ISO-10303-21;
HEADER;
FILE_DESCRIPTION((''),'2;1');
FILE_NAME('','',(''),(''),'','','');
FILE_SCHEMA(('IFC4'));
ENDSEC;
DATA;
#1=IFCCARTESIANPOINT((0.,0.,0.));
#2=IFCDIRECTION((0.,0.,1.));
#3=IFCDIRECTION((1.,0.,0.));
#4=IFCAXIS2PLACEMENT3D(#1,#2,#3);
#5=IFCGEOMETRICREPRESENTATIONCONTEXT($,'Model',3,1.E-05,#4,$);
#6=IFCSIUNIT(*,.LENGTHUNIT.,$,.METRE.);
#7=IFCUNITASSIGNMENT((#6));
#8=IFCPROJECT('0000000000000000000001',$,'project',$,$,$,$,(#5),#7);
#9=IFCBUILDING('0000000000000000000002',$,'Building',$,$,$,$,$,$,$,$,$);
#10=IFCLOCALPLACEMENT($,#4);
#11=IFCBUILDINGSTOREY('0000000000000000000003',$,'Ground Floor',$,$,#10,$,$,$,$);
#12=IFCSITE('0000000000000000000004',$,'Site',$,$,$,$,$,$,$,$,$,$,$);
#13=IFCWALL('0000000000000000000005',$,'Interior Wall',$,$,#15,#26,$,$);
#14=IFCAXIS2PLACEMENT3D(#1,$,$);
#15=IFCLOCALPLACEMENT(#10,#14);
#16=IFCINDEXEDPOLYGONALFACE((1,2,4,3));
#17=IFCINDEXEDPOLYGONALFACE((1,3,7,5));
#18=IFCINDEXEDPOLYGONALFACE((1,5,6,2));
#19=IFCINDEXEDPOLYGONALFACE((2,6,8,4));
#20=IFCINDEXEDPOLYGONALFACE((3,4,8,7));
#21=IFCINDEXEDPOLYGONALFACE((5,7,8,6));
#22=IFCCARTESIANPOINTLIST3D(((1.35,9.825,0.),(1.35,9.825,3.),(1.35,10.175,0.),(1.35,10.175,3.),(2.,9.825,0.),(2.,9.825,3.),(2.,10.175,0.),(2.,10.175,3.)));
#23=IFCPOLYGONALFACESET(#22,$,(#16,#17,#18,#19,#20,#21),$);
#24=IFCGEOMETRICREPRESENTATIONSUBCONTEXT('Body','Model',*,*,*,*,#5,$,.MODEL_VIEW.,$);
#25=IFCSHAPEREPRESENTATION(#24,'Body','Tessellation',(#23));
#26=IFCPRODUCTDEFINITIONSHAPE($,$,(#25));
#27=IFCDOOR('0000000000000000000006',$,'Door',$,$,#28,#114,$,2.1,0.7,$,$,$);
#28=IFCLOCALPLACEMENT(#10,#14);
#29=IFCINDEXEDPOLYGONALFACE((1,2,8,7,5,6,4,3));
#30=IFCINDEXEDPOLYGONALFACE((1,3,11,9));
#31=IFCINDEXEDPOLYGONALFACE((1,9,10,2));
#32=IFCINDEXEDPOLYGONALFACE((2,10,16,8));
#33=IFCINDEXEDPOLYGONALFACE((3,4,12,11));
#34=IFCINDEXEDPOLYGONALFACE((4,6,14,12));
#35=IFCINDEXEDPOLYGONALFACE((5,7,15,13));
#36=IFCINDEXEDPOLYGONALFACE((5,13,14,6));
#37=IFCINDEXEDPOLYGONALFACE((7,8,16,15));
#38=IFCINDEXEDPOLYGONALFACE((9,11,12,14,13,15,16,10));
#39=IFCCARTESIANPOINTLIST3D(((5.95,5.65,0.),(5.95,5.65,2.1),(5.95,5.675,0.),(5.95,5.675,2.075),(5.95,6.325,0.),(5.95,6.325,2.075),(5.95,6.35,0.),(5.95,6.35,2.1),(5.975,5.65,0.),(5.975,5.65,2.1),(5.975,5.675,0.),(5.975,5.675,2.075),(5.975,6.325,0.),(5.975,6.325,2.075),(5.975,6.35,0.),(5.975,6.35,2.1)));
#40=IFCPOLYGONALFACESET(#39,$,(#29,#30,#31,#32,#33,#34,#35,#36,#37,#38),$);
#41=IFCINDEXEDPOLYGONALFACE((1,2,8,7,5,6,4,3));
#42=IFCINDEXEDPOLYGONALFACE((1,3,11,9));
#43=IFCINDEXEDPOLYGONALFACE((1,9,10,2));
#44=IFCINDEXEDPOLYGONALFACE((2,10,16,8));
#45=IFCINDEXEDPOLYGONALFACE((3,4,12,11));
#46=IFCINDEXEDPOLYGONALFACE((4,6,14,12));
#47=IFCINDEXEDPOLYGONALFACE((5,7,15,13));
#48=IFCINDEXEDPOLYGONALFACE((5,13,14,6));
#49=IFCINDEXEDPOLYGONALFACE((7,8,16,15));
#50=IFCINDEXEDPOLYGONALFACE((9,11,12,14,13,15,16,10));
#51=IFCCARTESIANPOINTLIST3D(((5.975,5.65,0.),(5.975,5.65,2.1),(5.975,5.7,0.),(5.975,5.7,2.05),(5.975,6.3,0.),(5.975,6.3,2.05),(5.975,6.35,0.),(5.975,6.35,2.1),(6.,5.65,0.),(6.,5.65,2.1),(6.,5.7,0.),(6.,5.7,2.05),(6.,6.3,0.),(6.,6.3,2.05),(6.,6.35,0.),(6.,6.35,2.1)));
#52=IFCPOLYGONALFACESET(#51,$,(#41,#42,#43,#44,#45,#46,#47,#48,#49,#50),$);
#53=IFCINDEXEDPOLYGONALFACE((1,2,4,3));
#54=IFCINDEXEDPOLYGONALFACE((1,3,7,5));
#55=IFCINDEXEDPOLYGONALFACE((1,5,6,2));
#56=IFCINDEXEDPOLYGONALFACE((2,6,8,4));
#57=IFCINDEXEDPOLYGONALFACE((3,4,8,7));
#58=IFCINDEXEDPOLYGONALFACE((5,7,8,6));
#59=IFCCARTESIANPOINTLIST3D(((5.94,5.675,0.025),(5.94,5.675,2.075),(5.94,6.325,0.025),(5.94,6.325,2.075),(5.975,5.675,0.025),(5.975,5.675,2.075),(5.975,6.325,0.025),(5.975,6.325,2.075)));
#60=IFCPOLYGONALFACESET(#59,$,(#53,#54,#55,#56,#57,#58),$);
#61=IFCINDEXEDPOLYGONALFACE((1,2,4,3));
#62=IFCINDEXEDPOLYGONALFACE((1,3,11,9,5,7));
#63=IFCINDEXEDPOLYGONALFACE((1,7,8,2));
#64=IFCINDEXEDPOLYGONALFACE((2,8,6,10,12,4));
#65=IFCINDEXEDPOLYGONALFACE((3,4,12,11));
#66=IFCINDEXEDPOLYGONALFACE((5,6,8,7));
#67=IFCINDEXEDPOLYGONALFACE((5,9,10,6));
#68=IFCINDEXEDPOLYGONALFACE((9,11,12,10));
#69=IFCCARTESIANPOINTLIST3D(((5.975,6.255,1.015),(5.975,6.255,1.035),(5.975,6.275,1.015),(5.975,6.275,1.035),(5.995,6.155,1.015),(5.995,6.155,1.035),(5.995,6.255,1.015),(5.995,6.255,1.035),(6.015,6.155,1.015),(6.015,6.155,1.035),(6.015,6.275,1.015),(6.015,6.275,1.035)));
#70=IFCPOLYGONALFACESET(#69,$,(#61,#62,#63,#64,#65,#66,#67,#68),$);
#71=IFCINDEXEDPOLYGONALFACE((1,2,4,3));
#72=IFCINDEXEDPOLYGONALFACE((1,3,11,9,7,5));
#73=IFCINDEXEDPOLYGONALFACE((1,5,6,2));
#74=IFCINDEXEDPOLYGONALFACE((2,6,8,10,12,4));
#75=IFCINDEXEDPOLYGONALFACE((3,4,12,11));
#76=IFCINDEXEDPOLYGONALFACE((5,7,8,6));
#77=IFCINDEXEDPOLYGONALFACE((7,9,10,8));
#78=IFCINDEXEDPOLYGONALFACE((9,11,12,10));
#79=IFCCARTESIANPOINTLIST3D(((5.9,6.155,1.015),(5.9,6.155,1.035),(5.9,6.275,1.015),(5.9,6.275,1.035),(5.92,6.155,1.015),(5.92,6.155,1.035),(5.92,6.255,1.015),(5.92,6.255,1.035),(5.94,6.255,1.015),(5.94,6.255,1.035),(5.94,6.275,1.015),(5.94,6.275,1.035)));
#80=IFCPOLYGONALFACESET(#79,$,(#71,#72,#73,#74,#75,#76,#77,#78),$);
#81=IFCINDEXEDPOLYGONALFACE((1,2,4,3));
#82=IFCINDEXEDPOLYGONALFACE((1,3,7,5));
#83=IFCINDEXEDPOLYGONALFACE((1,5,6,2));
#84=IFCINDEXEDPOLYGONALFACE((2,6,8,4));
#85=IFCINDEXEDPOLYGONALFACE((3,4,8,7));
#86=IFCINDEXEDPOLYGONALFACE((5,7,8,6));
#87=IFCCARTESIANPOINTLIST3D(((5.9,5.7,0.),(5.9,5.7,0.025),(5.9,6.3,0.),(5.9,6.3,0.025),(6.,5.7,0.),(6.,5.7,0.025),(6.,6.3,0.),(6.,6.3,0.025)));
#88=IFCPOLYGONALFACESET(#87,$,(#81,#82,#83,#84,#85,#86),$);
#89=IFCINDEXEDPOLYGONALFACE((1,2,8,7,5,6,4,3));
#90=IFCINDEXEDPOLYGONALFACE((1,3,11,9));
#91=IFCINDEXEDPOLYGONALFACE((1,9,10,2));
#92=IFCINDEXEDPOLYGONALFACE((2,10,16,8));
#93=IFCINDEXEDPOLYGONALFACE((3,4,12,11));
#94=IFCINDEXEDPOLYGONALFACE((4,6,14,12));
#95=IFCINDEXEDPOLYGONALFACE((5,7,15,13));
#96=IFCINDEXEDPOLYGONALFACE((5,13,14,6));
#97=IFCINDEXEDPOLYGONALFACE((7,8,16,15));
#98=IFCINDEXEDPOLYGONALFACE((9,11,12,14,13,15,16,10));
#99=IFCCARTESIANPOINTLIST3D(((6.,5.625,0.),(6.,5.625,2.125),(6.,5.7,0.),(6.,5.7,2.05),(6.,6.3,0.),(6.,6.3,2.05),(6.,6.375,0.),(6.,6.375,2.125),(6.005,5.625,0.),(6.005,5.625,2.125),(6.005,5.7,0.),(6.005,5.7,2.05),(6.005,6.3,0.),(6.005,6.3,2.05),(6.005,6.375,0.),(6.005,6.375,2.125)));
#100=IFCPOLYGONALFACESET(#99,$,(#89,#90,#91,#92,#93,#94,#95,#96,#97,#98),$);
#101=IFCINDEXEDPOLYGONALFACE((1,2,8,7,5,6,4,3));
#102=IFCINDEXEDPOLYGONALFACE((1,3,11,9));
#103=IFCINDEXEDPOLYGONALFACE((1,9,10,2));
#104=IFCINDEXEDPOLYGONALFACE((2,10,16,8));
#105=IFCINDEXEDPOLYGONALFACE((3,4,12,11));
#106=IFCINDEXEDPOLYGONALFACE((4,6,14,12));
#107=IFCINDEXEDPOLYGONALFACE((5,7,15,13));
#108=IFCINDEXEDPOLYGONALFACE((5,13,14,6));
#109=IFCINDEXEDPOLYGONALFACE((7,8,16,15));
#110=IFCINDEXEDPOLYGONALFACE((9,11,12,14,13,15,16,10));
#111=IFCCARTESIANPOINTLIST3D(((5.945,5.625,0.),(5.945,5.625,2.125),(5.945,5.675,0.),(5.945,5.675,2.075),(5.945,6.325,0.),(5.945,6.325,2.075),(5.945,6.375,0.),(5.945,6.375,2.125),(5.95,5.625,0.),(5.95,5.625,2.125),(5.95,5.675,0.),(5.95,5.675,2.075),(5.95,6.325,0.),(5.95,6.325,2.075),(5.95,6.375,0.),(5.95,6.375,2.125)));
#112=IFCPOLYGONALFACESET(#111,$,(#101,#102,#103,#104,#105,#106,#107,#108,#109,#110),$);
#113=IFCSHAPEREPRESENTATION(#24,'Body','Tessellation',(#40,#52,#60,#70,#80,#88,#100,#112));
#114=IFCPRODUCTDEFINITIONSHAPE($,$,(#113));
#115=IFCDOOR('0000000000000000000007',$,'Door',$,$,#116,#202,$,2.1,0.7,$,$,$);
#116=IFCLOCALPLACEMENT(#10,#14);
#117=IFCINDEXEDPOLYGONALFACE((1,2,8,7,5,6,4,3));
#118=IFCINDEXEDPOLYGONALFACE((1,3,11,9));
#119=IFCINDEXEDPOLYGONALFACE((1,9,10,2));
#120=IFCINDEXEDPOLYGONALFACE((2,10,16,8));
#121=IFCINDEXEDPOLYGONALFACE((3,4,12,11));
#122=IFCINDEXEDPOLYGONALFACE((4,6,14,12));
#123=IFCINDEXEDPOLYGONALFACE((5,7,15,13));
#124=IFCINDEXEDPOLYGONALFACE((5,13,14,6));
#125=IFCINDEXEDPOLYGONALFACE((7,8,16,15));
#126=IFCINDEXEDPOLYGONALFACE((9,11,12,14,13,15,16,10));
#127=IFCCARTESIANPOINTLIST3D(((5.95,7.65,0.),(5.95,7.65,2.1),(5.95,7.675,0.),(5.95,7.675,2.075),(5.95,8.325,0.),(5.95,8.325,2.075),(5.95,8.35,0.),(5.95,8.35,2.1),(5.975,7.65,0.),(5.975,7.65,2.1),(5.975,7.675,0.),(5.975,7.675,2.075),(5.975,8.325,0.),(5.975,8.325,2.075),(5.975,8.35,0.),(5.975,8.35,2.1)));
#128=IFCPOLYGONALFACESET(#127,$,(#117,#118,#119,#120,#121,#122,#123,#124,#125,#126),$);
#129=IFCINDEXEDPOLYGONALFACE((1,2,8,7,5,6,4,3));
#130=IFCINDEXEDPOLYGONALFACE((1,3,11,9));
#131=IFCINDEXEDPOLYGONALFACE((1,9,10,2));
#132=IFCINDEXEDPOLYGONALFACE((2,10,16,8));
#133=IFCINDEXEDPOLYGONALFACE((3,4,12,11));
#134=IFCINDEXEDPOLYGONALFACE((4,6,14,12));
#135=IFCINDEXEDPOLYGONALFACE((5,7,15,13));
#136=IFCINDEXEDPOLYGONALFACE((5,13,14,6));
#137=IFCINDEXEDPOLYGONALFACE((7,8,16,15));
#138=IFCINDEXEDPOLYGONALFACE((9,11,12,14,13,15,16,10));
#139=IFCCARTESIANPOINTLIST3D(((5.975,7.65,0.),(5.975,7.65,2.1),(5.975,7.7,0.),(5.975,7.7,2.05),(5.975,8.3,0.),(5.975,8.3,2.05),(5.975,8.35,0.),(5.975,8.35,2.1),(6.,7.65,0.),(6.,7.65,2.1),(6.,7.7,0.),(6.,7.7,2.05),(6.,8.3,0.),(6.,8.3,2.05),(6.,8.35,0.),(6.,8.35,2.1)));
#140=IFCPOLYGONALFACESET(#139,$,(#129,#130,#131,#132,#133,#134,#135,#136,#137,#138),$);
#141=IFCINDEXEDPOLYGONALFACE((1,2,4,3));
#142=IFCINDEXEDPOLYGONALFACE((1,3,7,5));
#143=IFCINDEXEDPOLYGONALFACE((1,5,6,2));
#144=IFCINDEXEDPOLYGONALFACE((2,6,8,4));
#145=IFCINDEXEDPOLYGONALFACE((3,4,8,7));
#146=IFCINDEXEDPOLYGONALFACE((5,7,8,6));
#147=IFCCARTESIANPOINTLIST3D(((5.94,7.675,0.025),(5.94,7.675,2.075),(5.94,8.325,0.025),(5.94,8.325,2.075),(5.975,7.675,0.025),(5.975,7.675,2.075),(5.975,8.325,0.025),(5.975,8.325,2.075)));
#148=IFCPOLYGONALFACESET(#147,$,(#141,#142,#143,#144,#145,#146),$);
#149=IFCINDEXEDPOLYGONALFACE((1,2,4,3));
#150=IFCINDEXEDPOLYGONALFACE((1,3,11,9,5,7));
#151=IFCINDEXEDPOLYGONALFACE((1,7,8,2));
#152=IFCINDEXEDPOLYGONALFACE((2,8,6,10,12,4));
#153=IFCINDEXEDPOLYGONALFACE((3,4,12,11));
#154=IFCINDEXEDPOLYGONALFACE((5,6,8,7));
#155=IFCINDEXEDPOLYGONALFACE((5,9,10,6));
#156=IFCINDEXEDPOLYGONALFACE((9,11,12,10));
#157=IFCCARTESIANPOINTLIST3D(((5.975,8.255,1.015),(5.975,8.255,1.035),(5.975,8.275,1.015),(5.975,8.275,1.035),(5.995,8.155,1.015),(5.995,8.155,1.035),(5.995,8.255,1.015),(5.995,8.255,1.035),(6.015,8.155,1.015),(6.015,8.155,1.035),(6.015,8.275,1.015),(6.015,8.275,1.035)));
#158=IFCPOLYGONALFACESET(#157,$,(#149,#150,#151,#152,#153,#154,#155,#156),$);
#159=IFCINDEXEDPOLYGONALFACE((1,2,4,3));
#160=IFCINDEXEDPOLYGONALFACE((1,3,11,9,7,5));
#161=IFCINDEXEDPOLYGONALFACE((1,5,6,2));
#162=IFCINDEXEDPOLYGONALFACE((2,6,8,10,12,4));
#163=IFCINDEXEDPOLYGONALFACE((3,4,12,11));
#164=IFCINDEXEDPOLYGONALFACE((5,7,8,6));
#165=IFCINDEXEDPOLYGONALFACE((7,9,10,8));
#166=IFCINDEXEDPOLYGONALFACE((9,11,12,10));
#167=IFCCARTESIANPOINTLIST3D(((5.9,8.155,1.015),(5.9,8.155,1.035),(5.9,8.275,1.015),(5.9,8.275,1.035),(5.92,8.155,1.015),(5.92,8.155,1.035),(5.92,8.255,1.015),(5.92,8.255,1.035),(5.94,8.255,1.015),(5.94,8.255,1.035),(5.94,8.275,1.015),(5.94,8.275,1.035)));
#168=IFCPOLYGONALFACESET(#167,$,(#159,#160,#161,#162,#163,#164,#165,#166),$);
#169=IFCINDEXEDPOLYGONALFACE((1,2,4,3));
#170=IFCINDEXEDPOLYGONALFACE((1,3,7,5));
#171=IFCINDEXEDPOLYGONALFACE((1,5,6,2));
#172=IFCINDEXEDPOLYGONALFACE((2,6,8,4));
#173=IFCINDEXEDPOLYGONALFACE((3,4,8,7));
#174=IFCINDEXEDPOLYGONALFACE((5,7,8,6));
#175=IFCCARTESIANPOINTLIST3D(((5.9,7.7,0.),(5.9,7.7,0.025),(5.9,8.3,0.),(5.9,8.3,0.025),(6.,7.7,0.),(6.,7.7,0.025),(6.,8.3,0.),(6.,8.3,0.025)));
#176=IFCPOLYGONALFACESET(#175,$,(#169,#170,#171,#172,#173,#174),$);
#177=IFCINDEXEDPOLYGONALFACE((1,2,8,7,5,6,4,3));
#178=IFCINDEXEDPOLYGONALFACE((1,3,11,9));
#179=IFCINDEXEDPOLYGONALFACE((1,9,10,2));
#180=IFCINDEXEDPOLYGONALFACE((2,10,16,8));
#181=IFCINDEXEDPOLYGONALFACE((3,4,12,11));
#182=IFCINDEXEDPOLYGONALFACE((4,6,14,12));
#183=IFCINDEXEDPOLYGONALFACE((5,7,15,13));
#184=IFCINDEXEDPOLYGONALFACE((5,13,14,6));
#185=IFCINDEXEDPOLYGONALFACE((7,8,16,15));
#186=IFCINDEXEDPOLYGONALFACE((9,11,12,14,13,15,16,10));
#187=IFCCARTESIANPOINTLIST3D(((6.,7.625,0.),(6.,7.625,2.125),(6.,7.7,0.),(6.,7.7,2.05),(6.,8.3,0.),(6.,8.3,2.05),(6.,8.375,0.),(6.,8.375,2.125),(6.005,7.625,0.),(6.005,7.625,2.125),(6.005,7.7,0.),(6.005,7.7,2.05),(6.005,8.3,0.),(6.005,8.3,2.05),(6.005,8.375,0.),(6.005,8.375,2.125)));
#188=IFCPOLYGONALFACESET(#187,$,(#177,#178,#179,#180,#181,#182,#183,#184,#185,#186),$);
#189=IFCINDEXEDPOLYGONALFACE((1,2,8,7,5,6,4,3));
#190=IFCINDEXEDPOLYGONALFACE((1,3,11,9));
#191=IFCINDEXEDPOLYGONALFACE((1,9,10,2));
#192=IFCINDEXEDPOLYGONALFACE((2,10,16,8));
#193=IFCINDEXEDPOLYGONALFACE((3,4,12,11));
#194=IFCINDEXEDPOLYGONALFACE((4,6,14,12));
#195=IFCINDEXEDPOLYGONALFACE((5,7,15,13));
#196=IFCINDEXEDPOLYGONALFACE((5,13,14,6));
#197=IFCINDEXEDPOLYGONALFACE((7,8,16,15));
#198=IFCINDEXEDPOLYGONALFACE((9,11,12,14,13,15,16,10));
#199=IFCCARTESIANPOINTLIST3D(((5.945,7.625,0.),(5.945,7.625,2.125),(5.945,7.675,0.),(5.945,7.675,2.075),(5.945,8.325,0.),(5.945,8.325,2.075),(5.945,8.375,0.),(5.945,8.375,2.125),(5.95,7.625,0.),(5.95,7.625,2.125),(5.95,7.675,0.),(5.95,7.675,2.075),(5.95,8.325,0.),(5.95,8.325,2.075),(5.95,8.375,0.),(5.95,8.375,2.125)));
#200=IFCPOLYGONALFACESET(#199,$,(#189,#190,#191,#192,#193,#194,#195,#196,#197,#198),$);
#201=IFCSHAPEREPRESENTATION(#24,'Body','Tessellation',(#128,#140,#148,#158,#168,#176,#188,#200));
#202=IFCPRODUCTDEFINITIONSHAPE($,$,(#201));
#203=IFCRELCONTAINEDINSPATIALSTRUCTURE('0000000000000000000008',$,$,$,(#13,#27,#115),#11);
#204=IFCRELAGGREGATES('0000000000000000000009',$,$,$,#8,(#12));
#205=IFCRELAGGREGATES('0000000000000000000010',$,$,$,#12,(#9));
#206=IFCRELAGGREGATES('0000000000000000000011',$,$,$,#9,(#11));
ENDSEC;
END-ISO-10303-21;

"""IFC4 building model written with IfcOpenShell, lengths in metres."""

from ifc_helpers import new_model, si_unit, frame, origin_with_axes, place, context, subcontext, project, spatial, line, indexed_curve, outline, extrude, element, save


model = new_model("IFC4")

# Units and contexts
model_context = context("Model", 3, precision=1e-05, world=origin_with_axes())
body_context = subcontext(model_context, "Body", "Model", "MODEL_VIEW")
ifc_project = project(units=[si_unit("LENGTHUNIT", "METRE")], contexts=[model_context])

# Site, building, storey
site = spatial("IfcSite", under=ifc_project, Name="Site")
building = spatial("IfcBuilding", under=site, Name="Building")
storey_placement = place(None, origin_with_axes())
storey = spatial("IfcBuildingStorey", under=building, at=storey_placement, Name="Ground Floor")

# Wall
wall_1_placement = place(storey_placement, frame((1.35, 10.0, 0.0), z_axis=(0.0, 0.0, 1.0), x_axis=(1.0, 0.0, 0.0)))
element("IfcWall", 1, at=wall_1_placement, inside=storey, Name="Interior Wall", context=body_context, shape_type="SweptSolid", body=[
    extrude(outline(indexed_curve([(0.0, 0.0), (0.0, 0.35), (0.65, 0.35), (0.65, 0.0), (0.0, 0.0)], self_intersect=False)), frame((0.0, -0.175, 0.0), z_axis=(0.0, 0.0, 1.0), x_axis=(1.0, 0.0, 0.0)), (0.0, 0.0, 1.0), 3.0),
])

# Doors
door_1_placement = place(storey_placement, frame((6.0, 5.65, 0.0), z_axis=(0.0, 0.0, 1.0), x_axis=(0.0, 1.0, 0.0)))
element("IfcDoor", 2, at=door_1_placement, inside=storey, Name="Door", OverallHeight=2.1, OverallWidth=0.7, context=body_context, shape_type="SweptSolid", body=[
    extrude(outline(indexed_curve([(0.0, 0.0), (0.0, 2.1), (0.7, 2.1), (0.7, 0.0), (0.675, 0.0), (0.675, 2.075), (0.025, 2.075), (0.025, 0.0)], segments=[line(1, 2, 3, 4, 5, 6, 7, 8, 1)])), frame((0.0, 0.025, 0.0), z_axis=(0.0, -1.0, 0.0), x_axis=(1.0, 0.0, 0.0)), (0.0, 0.0, -1.0), 0.025),
    extrude(outline(indexed_curve([(0.0, 0.0), (0.0, 2.1), (0.7, 2.1), (0.7, 0.0), (0.65, 0.0), (0.65, 2.05), (0.05, 2.05), (0.05, 0.0)], segments=[line(1, 2, 3, 4, 5, 6, 7, 8, 1)])), frame((0.0, 0.0, 0.0), z_axis=(0.0, -1.0, 0.0), x_axis=(1.0, 0.0, 0.0)), (0.0, 0.0, -1.0), 0.025),
    extrude(outline(indexed_curve([(0.0, 0.0), (0.65, 0.0), (0.65, 0.035), (0.0, 0.035)], segments=[line(1, 2, 3, 4, 1)])), frame((0.025, 0.025, 0.025), z_axis=(0.0, 0.0, 1.0), x_axis=(1.0, 0.0, 0.0)), (0.0, 0.0, 1.0), 2.05),
    extrude(outline(indexed_curve([(0.0, 0.0), (0.0, -0.04), (-0.12, -0.04), (-0.12, -0.02), (-0.02, -0.02), (-0.02, 0.0)], segments=[line(1, 2, 3, 4, 5, 6, 1)])), frame((0.625, 0.025, 1.015), z_axis=(0.0, 0.0, 1.0), x_axis=(1.0, 0.0, 0.0)), (0.0, 0.0, 1.0), 0.02),
    extrude(outline(indexed_curve([(0.0, 0.0), (0.0, 0.04), (-0.12, 0.04), (-0.12, 0.02), (-0.02, 0.02), (-0.02, 0.0)], segments=[line(1, 2, 3, 4, 5, 6, 1)])), frame((0.625, 0.06, 1.015), z_axis=(0.0, 0.0, 1.0), x_axis=(1.0, 0.0, 0.0)), (0.0, 0.0, 1.0), 0.02),
    extrude(outline(indexed_curve([(0.0, 0.0), (0.6, 0.0), (0.6, 0.1), (0.0, 0.1)], segments=[line(1, 2, 3, 4, 1)])), frame((0.05, 0.0, 0.0), z_axis=(0.0, 0.0, 1.0), x_axis=(1.0, 0.0, 0.0)), (0.0, 0.0, 1.0), 0.025),
    extrude(outline(indexed_curve([(0.0, 0.0), (0.0, 2.125), (0.75, 2.125), (0.75, 0.0), (0.675, 0.0), (0.675, 2.05), (0.075, 2.05), (0.075, 0.0)], segments=[line(1, 2, 3, 4, 5, 6, 7, 8, 1)])), frame((-0.025, -0.005, 0.0), z_axis=(0.0, -1.0, 0.0), x_axis=(1.0, 0.0, 0.0)), (0.0, 0.0, -1.0), 0.005),
    extrude(outline(indexed_curve([(0.0, 0.0), (0.0, 2.125), (0.75, 2.125), (0.75, 0.0), (0.7, 0.0), (0.7, 2.075), (0.05, 2.075), (0.05, 0.0)], segments=[line(1, 2, 3, 4, 5, 6, 7, 8, 1)])), frame((-0.025, 0.05, 0.0), z_axis=(0.0, -1.0, 0.0), x_axis=(1.0, 0.0, 0.0)), (0.0, 0.0, -1.0), 0.005),
])
door_2_placement = place(storey_placement, frame((6.0, 7.65, 0.0), z_axis=(0.0, 0.0, 1.0), x_axis=(0.0, 1.0, 0.0)))
element("IfcDoor", 3, at=door_2_placement, inside=storey, Name="Door", OverallHeight=2.1, OverallWidth=0.7, context=body_context, shape_type="SweptSolid", body=[
    extrude(outline(indexed_curve([(0.0, 0.0), (0.0, 2.1), (0.7, 2.1), (0.7, 0.0), (0.675, 0.0), (0.675, 2.075), (0.025, 2.075), (0.025, 0.0)], segments=[line(1, 2, 3, 4, 5, 6, 7, 8, 1)])), frame((0.0, 0.025, 0.0), z_axis=(0.0, -1.0, 0.0), x_axis=(1.0, 0.0, 0.0)), (0.0, 0.0, -1.0), 0.025),
    extrude(outline(indexed_curve([(0.0, 0.0), (0.0, 2.1), (0.7, 2.1), (0.7, 0.0), (0.65, 0.0), (0.65, 2.05), (0.05, 2.05), (0.05, 0.0)], segments=[line(1, 2, 3, 4, 5, 6, 7, 8, 1)])), frame((0.0, 0.0, 0.0), z_axis=(0.0, -1.0, 0.0), x_axis=(1.0, 0.0, 0.0)), (0.0, 0.0, -1.0), 0.025),
    extrude(outline(indexed_curve([(0.0, 0.0), (0.65, 0.0), (0.65, 0.035), (0.0, 0.035)], segments=[line(1, 2, 3, 4, 1)])), frame((0.025, 0.025, 0.025), z_axis=(0.0, 0.0, 1.0), x_axis=(1.0, 0.0, 0.0)), (0.0, 0.0, 1.0), 2.05),
    extrude(outline(indexed_curve([(0.0, 0.0), (0.0, -0.04), (-0.12, -0.04), (-0.12, -0.02), (-0.02, -0.02), (-0.02, 0.0)], segments=[line(1, 2, 3, 4, 5, 6, 1)])), frame((0.625, 0.025, 1.015), z_axis=(0.0, 0.0, 1.0), x_axis=(1.0, 0.0, 0.0)), (0.0, 0.0, 1.0), 0.02),
    extrude(outline(indexed_curve([(0.0, 0.0), (0.0, 0.04), (-0.12, 0.04), (-0.12, 0.02), (-0.02, 0.02), (-0.02, 0.0)], segments=[line(1, 2, 3, 4, 5, 6, 1)])), frame((0.625, 0.06, 1.015), z_axis=(0.0, 0.0, 1.0), x_axis=(1.0, 0.0, 0.0)), (0.0, 0.0, 1.0), 0.02),
    extrude(outline(indexed_curve([(0.0, 0.0), (0.6, 0.0), (0.6, 0.1), (0.0, 0.1)], segments=[line(1, 2, 3, 4, 1)])), frame((0.05, 0.0, 0.0), z_axis=(0.0, 0.0, 1.0), x_axis=(1.0, 0.0, 0.0)), (0.0, 0.0, 1.0), 0.025),
    extrude(outline(indexed_curve([(0.0, 0.0), (0.0, 2.125), (0.75, 2.125), (0.75, 0.0), (0.675, 0.0), (0.675, 2.05), (0.075, 2.05), (0.075, 0.0)], segments=[line(1, 2, 3, 4, 5, 6, 7, 8, 1)])), frame((-0.025, -0.005, 0.0), z_axis=(0.0, -1.0, 0.0), x_axis=(1.0, 0.0, 0.0)), (0.0, 0.0, -1.0), 0.005),
    extrude(outline(indexed_curve([(0.0, 0.0), (0.0, 2.125), (0.75, 2.125), (0.75, 0.0), (0.7, 0.0), (0.7, 2.075), (0.05, 2.075), (0.05, 0.0)], segments=[line(1, 2, 3, 4, 5, 6, 7, 8, 1)])), frame((-0.025, 0.05, 0.0), z_axis=(0.0, -1.0, 0.0), x_axis=(1.0, 0.0, 0.0)), (0.0, 0.0, -1.0), 0.005),
])

save(model, "model.ifc")
